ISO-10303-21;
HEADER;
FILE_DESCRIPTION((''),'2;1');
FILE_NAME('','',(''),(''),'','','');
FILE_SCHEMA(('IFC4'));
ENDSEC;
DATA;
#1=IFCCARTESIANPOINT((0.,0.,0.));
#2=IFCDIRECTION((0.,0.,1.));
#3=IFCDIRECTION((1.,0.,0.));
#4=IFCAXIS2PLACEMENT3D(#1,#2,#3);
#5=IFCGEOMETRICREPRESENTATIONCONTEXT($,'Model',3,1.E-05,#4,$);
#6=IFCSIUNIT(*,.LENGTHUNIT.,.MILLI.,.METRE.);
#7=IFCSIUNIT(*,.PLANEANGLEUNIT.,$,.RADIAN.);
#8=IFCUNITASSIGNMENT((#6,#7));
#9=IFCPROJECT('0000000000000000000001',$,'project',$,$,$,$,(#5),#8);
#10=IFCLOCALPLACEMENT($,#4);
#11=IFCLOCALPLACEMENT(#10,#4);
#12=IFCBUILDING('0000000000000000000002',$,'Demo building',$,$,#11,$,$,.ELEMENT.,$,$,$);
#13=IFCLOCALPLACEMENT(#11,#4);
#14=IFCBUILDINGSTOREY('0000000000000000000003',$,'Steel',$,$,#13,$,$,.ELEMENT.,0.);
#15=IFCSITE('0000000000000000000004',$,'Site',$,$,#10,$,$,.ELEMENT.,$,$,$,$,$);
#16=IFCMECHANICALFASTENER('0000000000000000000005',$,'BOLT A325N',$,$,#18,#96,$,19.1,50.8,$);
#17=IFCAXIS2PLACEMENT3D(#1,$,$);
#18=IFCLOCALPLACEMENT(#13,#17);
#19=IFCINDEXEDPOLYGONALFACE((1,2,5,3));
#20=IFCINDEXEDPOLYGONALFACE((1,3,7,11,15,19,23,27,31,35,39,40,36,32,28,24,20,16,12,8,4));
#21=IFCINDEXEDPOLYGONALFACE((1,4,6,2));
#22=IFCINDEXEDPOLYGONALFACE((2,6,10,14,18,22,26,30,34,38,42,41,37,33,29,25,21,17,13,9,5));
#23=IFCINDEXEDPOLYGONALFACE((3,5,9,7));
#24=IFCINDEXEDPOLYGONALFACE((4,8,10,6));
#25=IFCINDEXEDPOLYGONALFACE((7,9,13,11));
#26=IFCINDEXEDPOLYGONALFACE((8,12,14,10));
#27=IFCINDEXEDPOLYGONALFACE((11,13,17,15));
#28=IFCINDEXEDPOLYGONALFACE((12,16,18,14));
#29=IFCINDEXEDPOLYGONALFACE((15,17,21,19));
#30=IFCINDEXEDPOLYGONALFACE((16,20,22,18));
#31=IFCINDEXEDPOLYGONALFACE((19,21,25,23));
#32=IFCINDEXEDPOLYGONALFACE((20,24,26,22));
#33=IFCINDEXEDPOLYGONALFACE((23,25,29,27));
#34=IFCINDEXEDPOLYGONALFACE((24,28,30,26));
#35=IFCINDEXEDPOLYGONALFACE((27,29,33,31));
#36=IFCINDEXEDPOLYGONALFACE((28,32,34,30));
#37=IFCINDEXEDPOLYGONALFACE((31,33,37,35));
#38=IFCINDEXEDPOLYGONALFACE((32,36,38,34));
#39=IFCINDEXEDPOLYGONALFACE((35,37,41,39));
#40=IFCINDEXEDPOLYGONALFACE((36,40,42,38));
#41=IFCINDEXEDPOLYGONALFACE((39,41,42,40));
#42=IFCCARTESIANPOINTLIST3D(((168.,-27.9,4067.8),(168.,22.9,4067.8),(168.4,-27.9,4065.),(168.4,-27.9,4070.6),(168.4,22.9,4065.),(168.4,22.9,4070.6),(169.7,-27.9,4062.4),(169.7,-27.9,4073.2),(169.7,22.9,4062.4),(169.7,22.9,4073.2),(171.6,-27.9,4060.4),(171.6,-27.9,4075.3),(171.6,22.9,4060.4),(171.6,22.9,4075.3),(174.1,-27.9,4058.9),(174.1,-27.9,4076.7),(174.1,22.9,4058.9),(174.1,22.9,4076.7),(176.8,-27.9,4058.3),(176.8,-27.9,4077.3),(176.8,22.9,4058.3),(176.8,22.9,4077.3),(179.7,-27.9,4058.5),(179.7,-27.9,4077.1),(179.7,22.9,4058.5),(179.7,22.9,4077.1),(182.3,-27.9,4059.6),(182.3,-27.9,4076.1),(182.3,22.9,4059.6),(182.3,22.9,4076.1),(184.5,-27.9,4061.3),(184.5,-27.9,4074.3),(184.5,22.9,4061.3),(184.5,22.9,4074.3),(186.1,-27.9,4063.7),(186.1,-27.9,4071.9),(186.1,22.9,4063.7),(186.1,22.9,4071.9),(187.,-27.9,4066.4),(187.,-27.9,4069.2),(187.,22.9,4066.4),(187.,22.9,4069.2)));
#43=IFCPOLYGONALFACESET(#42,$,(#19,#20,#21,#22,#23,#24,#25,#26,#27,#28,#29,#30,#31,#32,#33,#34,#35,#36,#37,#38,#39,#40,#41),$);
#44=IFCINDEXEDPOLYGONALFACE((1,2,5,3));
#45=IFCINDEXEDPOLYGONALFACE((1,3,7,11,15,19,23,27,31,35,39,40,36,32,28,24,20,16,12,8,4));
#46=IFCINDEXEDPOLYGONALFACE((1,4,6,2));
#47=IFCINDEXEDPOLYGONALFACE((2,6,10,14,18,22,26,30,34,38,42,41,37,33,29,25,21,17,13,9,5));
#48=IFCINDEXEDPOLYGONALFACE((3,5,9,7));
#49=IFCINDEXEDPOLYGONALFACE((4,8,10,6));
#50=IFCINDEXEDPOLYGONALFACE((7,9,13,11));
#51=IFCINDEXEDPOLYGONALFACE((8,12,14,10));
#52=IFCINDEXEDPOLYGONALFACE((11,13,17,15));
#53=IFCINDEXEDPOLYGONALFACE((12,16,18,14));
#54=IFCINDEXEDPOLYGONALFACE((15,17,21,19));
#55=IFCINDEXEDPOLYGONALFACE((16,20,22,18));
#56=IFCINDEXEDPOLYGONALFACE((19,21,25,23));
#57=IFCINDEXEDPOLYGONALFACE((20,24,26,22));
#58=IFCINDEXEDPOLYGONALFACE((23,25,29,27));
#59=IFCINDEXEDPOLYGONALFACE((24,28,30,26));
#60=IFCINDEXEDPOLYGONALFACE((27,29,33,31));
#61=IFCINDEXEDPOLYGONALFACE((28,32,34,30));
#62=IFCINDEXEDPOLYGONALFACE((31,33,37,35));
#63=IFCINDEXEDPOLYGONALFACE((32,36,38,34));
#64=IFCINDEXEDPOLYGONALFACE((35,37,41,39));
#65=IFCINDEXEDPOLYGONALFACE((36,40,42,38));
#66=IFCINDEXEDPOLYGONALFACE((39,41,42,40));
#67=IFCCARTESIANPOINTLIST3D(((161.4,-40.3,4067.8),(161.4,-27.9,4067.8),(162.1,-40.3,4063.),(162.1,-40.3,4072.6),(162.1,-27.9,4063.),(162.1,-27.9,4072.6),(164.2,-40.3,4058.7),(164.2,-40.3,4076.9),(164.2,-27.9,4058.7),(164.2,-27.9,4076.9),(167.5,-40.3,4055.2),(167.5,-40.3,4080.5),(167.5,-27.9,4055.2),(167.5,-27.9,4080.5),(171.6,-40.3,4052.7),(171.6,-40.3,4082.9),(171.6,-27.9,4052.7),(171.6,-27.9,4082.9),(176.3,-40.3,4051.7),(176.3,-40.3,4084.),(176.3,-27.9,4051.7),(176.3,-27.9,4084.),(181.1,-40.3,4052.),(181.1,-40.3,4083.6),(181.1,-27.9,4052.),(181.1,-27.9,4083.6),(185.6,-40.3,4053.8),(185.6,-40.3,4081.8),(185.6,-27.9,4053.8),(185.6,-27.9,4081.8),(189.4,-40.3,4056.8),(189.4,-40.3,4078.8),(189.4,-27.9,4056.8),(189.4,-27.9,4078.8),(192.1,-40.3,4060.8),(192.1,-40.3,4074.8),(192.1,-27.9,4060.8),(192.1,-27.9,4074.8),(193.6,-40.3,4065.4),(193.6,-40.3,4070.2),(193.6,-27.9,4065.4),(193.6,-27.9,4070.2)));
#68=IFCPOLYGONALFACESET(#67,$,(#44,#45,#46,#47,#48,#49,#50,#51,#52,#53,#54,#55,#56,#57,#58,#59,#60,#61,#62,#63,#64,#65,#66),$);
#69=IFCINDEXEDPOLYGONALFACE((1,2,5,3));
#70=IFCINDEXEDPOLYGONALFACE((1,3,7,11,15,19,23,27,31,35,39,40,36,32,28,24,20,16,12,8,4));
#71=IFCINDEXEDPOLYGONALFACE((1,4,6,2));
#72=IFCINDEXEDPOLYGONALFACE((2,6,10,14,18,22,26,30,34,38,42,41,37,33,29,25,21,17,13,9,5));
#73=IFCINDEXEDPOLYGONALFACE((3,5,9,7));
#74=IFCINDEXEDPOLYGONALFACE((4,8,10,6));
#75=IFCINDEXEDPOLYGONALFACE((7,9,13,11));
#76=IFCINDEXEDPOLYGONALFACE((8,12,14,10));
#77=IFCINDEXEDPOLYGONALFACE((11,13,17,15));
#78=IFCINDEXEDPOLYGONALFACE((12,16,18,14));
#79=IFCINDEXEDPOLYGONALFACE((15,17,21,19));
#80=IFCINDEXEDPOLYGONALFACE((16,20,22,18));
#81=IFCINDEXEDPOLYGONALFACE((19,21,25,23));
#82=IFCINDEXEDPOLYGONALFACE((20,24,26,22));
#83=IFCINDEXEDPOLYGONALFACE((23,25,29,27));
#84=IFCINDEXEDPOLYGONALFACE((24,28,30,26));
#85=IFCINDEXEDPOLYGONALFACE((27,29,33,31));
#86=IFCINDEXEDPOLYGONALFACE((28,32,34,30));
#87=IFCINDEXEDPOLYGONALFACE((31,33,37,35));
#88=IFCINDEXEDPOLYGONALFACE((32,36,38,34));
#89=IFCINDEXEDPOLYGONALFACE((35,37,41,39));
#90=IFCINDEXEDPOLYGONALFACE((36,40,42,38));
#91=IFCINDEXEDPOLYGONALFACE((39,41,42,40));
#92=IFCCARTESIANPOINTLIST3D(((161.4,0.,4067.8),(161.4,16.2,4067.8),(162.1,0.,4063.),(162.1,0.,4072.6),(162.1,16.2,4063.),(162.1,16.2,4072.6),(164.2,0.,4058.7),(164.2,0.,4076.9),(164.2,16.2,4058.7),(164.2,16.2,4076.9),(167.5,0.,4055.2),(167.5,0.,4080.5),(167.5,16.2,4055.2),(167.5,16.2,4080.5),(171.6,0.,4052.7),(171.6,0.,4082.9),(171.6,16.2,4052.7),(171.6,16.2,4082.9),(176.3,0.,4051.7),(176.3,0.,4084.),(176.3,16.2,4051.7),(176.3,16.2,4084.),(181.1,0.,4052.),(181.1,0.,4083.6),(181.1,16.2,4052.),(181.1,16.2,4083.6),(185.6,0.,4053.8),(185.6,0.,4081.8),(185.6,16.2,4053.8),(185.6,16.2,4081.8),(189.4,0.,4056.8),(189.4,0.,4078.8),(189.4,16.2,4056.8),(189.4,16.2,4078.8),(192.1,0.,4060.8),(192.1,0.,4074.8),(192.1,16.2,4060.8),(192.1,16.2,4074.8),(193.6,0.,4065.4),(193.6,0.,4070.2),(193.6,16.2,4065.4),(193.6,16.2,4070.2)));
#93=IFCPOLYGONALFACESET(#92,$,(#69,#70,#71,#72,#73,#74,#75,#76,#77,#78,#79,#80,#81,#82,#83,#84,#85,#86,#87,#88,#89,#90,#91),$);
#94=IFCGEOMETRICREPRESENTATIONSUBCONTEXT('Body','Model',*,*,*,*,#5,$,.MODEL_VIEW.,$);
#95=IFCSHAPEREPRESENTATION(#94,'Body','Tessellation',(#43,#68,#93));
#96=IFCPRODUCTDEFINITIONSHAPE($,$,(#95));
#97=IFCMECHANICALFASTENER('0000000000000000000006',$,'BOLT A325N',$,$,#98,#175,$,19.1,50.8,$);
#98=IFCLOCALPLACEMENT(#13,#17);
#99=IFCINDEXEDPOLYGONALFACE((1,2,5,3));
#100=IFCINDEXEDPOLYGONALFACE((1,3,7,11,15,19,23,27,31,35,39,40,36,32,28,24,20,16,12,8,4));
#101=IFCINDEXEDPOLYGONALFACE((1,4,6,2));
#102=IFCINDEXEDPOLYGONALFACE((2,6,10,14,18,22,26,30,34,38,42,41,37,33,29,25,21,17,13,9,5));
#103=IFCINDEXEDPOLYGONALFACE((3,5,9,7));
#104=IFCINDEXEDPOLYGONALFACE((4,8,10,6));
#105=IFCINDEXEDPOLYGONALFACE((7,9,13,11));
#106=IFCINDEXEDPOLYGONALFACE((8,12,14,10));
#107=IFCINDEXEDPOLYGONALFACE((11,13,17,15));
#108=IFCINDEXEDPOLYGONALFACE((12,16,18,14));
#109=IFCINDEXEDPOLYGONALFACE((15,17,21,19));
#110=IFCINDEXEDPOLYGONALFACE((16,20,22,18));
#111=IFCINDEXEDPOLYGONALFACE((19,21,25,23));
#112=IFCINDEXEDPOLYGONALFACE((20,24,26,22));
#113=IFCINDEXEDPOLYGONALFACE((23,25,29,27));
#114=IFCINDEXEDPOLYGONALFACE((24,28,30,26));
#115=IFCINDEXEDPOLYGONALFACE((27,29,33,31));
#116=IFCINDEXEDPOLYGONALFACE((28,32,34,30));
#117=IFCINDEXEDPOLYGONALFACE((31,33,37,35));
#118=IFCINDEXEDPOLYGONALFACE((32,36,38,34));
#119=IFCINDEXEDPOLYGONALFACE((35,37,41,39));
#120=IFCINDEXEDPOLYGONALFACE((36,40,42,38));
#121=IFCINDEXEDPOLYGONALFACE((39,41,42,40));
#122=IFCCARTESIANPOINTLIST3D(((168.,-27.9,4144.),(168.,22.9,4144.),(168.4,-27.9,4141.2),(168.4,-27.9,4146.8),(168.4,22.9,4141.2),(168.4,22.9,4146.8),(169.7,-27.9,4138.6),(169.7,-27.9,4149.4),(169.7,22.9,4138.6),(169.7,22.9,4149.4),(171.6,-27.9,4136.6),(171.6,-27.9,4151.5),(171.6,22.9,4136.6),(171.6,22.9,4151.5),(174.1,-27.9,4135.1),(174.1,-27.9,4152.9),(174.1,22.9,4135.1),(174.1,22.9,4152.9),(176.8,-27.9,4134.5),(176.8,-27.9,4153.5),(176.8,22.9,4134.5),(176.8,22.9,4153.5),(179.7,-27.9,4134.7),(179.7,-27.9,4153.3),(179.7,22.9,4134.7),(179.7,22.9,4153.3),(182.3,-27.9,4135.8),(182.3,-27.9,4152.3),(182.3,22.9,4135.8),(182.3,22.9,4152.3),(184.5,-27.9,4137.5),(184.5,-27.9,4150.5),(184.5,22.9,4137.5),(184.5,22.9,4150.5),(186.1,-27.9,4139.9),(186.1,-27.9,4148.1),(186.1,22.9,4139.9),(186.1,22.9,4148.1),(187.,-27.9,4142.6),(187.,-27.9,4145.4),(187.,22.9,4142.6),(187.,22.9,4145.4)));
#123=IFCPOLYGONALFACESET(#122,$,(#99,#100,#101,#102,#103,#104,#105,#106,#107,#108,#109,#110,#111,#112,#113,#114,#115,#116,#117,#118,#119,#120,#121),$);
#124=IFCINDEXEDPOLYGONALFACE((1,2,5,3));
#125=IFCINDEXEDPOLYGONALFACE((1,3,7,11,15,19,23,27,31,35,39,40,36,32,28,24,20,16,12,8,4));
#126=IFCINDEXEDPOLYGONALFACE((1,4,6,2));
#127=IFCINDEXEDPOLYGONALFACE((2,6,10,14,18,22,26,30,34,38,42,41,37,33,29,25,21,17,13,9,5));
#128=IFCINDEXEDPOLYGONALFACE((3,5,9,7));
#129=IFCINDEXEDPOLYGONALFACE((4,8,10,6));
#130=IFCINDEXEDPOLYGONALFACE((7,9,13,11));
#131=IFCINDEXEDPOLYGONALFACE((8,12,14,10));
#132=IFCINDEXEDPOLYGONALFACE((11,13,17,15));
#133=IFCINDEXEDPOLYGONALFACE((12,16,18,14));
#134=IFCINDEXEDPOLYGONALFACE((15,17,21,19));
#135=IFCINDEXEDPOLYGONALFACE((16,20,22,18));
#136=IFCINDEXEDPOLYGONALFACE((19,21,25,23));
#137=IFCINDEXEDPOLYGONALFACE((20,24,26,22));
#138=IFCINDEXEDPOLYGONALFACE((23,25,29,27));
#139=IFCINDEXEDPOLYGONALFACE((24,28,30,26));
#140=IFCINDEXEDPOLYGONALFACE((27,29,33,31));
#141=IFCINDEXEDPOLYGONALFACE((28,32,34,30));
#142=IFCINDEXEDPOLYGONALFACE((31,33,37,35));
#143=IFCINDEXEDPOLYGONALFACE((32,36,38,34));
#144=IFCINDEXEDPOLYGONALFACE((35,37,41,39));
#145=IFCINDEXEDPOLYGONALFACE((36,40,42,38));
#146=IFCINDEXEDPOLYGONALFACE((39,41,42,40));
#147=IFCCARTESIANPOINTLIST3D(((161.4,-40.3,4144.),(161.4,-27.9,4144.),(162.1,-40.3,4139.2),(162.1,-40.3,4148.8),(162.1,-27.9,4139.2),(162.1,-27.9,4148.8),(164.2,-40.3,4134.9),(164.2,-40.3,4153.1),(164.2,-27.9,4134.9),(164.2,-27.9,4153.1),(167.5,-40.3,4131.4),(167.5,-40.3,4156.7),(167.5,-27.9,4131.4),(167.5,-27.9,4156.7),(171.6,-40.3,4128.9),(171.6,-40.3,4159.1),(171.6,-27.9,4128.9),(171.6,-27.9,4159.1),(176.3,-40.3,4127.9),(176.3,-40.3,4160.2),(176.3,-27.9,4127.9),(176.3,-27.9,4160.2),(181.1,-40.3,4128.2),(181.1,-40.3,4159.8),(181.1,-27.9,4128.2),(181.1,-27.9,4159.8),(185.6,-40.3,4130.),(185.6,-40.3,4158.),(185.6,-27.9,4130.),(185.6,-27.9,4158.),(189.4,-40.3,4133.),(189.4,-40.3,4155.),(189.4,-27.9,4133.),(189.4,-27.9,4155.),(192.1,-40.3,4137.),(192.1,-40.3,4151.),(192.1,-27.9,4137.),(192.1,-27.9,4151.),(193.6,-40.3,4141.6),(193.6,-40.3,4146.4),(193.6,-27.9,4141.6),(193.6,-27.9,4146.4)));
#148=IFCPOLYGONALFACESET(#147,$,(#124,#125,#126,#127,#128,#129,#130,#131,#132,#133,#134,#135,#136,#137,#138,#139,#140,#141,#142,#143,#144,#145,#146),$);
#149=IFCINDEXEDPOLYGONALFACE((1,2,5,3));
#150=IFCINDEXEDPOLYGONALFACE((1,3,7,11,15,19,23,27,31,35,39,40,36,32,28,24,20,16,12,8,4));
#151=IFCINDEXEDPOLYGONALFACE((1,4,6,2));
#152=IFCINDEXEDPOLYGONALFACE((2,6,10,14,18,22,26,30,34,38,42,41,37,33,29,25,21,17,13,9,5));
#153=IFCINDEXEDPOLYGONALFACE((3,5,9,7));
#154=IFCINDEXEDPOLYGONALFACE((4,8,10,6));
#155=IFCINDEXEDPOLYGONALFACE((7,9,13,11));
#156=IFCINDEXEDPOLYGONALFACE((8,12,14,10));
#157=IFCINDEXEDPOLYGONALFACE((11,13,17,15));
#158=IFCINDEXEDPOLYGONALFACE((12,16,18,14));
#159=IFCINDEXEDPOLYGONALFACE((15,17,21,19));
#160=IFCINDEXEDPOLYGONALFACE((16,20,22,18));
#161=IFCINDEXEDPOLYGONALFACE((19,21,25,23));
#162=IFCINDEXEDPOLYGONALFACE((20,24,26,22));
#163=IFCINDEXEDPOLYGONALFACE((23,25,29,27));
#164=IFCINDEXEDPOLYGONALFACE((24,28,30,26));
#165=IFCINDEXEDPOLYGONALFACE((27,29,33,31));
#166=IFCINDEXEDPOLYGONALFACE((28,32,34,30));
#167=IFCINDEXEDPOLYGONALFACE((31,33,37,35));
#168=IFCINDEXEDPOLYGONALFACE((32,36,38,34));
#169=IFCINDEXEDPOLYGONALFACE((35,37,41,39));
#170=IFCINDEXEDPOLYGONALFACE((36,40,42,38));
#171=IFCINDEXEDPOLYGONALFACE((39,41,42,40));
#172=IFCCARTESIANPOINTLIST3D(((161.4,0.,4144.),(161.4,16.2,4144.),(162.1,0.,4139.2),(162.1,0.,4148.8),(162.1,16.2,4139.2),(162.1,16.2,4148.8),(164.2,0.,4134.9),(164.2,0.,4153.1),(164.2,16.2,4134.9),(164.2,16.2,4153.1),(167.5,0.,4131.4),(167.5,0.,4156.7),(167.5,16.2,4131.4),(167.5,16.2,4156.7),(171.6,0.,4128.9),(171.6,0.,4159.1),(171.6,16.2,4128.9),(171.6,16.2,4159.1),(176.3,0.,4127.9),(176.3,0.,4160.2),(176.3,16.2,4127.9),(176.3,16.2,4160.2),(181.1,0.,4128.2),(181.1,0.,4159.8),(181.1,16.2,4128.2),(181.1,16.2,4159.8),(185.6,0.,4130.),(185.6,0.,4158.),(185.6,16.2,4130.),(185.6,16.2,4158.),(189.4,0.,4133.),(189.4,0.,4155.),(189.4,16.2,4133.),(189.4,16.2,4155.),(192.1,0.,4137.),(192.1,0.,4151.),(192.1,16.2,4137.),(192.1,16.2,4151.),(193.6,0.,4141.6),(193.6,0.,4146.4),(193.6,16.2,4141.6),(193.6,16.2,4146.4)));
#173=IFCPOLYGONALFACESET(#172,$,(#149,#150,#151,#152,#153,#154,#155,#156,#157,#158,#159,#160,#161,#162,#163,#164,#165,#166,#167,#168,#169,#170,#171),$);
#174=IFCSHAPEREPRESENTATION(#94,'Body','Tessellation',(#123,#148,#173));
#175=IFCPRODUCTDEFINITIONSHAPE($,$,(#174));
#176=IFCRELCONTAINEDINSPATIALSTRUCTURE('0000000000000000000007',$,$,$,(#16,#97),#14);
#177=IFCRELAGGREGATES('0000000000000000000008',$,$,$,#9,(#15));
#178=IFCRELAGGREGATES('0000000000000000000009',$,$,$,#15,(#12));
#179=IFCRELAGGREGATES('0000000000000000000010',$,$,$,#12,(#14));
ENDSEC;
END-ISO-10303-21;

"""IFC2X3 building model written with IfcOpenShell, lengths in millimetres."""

from ifc_helpers import new_model, si_unit, frame, origin, origin_with_axes, origin_2d, place, context, subcontext, project, spatial, circle, extrude, element, save


model = new_model("IFC2X3")

# Units and contexts
model_context = context("Model", 3, precision=1e-05, world=origin_with_axes())
body_context = subcontext(model_context, "Body", "Model", "MODEL_VIEW")
ifc_project = project(units=[si_unit("LENGTHUNIT", "METRE", prefix="MILLI"), si_unit("PLANEANGLEUNIT", "RADIAN")], contexts=[model_context])

# Site, building, storey
site_placement = place(None, origin_with_axes())
site = spatial("IfcSite", under=ifc_project, at=site_placement, Name="Site", CompositionType="ELEMENT")
building_placement = place(site_placement, origin_with_axes())
building = spatial("IfcBuilding", under=site, at=building_placement, Name="Demo building", CompositionType="ELEMENT")
placement = place(building_placement, origin_with_axes())
storey = spatial("IfcBuildingStorey", under=building, at=placement, Name="Steel", CompositionType="ELEMENT", Elevation=0.0)

# Mechanical fasteners
for number, where, z_axis, x_axis, name in (
    (1, (177.5, -27.9, 4067.8), (0.0, 1.0, 0.0), (-1.0, 0.0, 0.0), "BOLT A325N"),
    (2, (177.5, -27.9, 4144.0), (0.0, 1.0, 0.0), (-1.0, 0.0, 0.0), "BOLT A325N"),
):
    element("IfcMechanicalFastener", number, at=place(placement, frame(where, z_axis=z_axis, x_axis=x_axis)), inside=storey, Name=name, NominalDiameter=19.1, NominalLength=50.8, context=body_context, shape_type="SweptSolid", body=[
        extrude(circle(Radius=9.5, at=origin_2d()), origin(), (0.0, 0.0, 1.0), 50.8),
        extrude(circle(Radius=16.2, at=origin_2d()), frame((0.0, 0.0, -12.4)), (0.0, 0.0, 1.0), 12.4),
        extrude(circle(Radius=16.2, at=origin_2d()), frame((0.0, 0.0, 27.9)), (0.0, 0.0, 1.0), 16.2),
    ])

save(model, "model.ifc")
